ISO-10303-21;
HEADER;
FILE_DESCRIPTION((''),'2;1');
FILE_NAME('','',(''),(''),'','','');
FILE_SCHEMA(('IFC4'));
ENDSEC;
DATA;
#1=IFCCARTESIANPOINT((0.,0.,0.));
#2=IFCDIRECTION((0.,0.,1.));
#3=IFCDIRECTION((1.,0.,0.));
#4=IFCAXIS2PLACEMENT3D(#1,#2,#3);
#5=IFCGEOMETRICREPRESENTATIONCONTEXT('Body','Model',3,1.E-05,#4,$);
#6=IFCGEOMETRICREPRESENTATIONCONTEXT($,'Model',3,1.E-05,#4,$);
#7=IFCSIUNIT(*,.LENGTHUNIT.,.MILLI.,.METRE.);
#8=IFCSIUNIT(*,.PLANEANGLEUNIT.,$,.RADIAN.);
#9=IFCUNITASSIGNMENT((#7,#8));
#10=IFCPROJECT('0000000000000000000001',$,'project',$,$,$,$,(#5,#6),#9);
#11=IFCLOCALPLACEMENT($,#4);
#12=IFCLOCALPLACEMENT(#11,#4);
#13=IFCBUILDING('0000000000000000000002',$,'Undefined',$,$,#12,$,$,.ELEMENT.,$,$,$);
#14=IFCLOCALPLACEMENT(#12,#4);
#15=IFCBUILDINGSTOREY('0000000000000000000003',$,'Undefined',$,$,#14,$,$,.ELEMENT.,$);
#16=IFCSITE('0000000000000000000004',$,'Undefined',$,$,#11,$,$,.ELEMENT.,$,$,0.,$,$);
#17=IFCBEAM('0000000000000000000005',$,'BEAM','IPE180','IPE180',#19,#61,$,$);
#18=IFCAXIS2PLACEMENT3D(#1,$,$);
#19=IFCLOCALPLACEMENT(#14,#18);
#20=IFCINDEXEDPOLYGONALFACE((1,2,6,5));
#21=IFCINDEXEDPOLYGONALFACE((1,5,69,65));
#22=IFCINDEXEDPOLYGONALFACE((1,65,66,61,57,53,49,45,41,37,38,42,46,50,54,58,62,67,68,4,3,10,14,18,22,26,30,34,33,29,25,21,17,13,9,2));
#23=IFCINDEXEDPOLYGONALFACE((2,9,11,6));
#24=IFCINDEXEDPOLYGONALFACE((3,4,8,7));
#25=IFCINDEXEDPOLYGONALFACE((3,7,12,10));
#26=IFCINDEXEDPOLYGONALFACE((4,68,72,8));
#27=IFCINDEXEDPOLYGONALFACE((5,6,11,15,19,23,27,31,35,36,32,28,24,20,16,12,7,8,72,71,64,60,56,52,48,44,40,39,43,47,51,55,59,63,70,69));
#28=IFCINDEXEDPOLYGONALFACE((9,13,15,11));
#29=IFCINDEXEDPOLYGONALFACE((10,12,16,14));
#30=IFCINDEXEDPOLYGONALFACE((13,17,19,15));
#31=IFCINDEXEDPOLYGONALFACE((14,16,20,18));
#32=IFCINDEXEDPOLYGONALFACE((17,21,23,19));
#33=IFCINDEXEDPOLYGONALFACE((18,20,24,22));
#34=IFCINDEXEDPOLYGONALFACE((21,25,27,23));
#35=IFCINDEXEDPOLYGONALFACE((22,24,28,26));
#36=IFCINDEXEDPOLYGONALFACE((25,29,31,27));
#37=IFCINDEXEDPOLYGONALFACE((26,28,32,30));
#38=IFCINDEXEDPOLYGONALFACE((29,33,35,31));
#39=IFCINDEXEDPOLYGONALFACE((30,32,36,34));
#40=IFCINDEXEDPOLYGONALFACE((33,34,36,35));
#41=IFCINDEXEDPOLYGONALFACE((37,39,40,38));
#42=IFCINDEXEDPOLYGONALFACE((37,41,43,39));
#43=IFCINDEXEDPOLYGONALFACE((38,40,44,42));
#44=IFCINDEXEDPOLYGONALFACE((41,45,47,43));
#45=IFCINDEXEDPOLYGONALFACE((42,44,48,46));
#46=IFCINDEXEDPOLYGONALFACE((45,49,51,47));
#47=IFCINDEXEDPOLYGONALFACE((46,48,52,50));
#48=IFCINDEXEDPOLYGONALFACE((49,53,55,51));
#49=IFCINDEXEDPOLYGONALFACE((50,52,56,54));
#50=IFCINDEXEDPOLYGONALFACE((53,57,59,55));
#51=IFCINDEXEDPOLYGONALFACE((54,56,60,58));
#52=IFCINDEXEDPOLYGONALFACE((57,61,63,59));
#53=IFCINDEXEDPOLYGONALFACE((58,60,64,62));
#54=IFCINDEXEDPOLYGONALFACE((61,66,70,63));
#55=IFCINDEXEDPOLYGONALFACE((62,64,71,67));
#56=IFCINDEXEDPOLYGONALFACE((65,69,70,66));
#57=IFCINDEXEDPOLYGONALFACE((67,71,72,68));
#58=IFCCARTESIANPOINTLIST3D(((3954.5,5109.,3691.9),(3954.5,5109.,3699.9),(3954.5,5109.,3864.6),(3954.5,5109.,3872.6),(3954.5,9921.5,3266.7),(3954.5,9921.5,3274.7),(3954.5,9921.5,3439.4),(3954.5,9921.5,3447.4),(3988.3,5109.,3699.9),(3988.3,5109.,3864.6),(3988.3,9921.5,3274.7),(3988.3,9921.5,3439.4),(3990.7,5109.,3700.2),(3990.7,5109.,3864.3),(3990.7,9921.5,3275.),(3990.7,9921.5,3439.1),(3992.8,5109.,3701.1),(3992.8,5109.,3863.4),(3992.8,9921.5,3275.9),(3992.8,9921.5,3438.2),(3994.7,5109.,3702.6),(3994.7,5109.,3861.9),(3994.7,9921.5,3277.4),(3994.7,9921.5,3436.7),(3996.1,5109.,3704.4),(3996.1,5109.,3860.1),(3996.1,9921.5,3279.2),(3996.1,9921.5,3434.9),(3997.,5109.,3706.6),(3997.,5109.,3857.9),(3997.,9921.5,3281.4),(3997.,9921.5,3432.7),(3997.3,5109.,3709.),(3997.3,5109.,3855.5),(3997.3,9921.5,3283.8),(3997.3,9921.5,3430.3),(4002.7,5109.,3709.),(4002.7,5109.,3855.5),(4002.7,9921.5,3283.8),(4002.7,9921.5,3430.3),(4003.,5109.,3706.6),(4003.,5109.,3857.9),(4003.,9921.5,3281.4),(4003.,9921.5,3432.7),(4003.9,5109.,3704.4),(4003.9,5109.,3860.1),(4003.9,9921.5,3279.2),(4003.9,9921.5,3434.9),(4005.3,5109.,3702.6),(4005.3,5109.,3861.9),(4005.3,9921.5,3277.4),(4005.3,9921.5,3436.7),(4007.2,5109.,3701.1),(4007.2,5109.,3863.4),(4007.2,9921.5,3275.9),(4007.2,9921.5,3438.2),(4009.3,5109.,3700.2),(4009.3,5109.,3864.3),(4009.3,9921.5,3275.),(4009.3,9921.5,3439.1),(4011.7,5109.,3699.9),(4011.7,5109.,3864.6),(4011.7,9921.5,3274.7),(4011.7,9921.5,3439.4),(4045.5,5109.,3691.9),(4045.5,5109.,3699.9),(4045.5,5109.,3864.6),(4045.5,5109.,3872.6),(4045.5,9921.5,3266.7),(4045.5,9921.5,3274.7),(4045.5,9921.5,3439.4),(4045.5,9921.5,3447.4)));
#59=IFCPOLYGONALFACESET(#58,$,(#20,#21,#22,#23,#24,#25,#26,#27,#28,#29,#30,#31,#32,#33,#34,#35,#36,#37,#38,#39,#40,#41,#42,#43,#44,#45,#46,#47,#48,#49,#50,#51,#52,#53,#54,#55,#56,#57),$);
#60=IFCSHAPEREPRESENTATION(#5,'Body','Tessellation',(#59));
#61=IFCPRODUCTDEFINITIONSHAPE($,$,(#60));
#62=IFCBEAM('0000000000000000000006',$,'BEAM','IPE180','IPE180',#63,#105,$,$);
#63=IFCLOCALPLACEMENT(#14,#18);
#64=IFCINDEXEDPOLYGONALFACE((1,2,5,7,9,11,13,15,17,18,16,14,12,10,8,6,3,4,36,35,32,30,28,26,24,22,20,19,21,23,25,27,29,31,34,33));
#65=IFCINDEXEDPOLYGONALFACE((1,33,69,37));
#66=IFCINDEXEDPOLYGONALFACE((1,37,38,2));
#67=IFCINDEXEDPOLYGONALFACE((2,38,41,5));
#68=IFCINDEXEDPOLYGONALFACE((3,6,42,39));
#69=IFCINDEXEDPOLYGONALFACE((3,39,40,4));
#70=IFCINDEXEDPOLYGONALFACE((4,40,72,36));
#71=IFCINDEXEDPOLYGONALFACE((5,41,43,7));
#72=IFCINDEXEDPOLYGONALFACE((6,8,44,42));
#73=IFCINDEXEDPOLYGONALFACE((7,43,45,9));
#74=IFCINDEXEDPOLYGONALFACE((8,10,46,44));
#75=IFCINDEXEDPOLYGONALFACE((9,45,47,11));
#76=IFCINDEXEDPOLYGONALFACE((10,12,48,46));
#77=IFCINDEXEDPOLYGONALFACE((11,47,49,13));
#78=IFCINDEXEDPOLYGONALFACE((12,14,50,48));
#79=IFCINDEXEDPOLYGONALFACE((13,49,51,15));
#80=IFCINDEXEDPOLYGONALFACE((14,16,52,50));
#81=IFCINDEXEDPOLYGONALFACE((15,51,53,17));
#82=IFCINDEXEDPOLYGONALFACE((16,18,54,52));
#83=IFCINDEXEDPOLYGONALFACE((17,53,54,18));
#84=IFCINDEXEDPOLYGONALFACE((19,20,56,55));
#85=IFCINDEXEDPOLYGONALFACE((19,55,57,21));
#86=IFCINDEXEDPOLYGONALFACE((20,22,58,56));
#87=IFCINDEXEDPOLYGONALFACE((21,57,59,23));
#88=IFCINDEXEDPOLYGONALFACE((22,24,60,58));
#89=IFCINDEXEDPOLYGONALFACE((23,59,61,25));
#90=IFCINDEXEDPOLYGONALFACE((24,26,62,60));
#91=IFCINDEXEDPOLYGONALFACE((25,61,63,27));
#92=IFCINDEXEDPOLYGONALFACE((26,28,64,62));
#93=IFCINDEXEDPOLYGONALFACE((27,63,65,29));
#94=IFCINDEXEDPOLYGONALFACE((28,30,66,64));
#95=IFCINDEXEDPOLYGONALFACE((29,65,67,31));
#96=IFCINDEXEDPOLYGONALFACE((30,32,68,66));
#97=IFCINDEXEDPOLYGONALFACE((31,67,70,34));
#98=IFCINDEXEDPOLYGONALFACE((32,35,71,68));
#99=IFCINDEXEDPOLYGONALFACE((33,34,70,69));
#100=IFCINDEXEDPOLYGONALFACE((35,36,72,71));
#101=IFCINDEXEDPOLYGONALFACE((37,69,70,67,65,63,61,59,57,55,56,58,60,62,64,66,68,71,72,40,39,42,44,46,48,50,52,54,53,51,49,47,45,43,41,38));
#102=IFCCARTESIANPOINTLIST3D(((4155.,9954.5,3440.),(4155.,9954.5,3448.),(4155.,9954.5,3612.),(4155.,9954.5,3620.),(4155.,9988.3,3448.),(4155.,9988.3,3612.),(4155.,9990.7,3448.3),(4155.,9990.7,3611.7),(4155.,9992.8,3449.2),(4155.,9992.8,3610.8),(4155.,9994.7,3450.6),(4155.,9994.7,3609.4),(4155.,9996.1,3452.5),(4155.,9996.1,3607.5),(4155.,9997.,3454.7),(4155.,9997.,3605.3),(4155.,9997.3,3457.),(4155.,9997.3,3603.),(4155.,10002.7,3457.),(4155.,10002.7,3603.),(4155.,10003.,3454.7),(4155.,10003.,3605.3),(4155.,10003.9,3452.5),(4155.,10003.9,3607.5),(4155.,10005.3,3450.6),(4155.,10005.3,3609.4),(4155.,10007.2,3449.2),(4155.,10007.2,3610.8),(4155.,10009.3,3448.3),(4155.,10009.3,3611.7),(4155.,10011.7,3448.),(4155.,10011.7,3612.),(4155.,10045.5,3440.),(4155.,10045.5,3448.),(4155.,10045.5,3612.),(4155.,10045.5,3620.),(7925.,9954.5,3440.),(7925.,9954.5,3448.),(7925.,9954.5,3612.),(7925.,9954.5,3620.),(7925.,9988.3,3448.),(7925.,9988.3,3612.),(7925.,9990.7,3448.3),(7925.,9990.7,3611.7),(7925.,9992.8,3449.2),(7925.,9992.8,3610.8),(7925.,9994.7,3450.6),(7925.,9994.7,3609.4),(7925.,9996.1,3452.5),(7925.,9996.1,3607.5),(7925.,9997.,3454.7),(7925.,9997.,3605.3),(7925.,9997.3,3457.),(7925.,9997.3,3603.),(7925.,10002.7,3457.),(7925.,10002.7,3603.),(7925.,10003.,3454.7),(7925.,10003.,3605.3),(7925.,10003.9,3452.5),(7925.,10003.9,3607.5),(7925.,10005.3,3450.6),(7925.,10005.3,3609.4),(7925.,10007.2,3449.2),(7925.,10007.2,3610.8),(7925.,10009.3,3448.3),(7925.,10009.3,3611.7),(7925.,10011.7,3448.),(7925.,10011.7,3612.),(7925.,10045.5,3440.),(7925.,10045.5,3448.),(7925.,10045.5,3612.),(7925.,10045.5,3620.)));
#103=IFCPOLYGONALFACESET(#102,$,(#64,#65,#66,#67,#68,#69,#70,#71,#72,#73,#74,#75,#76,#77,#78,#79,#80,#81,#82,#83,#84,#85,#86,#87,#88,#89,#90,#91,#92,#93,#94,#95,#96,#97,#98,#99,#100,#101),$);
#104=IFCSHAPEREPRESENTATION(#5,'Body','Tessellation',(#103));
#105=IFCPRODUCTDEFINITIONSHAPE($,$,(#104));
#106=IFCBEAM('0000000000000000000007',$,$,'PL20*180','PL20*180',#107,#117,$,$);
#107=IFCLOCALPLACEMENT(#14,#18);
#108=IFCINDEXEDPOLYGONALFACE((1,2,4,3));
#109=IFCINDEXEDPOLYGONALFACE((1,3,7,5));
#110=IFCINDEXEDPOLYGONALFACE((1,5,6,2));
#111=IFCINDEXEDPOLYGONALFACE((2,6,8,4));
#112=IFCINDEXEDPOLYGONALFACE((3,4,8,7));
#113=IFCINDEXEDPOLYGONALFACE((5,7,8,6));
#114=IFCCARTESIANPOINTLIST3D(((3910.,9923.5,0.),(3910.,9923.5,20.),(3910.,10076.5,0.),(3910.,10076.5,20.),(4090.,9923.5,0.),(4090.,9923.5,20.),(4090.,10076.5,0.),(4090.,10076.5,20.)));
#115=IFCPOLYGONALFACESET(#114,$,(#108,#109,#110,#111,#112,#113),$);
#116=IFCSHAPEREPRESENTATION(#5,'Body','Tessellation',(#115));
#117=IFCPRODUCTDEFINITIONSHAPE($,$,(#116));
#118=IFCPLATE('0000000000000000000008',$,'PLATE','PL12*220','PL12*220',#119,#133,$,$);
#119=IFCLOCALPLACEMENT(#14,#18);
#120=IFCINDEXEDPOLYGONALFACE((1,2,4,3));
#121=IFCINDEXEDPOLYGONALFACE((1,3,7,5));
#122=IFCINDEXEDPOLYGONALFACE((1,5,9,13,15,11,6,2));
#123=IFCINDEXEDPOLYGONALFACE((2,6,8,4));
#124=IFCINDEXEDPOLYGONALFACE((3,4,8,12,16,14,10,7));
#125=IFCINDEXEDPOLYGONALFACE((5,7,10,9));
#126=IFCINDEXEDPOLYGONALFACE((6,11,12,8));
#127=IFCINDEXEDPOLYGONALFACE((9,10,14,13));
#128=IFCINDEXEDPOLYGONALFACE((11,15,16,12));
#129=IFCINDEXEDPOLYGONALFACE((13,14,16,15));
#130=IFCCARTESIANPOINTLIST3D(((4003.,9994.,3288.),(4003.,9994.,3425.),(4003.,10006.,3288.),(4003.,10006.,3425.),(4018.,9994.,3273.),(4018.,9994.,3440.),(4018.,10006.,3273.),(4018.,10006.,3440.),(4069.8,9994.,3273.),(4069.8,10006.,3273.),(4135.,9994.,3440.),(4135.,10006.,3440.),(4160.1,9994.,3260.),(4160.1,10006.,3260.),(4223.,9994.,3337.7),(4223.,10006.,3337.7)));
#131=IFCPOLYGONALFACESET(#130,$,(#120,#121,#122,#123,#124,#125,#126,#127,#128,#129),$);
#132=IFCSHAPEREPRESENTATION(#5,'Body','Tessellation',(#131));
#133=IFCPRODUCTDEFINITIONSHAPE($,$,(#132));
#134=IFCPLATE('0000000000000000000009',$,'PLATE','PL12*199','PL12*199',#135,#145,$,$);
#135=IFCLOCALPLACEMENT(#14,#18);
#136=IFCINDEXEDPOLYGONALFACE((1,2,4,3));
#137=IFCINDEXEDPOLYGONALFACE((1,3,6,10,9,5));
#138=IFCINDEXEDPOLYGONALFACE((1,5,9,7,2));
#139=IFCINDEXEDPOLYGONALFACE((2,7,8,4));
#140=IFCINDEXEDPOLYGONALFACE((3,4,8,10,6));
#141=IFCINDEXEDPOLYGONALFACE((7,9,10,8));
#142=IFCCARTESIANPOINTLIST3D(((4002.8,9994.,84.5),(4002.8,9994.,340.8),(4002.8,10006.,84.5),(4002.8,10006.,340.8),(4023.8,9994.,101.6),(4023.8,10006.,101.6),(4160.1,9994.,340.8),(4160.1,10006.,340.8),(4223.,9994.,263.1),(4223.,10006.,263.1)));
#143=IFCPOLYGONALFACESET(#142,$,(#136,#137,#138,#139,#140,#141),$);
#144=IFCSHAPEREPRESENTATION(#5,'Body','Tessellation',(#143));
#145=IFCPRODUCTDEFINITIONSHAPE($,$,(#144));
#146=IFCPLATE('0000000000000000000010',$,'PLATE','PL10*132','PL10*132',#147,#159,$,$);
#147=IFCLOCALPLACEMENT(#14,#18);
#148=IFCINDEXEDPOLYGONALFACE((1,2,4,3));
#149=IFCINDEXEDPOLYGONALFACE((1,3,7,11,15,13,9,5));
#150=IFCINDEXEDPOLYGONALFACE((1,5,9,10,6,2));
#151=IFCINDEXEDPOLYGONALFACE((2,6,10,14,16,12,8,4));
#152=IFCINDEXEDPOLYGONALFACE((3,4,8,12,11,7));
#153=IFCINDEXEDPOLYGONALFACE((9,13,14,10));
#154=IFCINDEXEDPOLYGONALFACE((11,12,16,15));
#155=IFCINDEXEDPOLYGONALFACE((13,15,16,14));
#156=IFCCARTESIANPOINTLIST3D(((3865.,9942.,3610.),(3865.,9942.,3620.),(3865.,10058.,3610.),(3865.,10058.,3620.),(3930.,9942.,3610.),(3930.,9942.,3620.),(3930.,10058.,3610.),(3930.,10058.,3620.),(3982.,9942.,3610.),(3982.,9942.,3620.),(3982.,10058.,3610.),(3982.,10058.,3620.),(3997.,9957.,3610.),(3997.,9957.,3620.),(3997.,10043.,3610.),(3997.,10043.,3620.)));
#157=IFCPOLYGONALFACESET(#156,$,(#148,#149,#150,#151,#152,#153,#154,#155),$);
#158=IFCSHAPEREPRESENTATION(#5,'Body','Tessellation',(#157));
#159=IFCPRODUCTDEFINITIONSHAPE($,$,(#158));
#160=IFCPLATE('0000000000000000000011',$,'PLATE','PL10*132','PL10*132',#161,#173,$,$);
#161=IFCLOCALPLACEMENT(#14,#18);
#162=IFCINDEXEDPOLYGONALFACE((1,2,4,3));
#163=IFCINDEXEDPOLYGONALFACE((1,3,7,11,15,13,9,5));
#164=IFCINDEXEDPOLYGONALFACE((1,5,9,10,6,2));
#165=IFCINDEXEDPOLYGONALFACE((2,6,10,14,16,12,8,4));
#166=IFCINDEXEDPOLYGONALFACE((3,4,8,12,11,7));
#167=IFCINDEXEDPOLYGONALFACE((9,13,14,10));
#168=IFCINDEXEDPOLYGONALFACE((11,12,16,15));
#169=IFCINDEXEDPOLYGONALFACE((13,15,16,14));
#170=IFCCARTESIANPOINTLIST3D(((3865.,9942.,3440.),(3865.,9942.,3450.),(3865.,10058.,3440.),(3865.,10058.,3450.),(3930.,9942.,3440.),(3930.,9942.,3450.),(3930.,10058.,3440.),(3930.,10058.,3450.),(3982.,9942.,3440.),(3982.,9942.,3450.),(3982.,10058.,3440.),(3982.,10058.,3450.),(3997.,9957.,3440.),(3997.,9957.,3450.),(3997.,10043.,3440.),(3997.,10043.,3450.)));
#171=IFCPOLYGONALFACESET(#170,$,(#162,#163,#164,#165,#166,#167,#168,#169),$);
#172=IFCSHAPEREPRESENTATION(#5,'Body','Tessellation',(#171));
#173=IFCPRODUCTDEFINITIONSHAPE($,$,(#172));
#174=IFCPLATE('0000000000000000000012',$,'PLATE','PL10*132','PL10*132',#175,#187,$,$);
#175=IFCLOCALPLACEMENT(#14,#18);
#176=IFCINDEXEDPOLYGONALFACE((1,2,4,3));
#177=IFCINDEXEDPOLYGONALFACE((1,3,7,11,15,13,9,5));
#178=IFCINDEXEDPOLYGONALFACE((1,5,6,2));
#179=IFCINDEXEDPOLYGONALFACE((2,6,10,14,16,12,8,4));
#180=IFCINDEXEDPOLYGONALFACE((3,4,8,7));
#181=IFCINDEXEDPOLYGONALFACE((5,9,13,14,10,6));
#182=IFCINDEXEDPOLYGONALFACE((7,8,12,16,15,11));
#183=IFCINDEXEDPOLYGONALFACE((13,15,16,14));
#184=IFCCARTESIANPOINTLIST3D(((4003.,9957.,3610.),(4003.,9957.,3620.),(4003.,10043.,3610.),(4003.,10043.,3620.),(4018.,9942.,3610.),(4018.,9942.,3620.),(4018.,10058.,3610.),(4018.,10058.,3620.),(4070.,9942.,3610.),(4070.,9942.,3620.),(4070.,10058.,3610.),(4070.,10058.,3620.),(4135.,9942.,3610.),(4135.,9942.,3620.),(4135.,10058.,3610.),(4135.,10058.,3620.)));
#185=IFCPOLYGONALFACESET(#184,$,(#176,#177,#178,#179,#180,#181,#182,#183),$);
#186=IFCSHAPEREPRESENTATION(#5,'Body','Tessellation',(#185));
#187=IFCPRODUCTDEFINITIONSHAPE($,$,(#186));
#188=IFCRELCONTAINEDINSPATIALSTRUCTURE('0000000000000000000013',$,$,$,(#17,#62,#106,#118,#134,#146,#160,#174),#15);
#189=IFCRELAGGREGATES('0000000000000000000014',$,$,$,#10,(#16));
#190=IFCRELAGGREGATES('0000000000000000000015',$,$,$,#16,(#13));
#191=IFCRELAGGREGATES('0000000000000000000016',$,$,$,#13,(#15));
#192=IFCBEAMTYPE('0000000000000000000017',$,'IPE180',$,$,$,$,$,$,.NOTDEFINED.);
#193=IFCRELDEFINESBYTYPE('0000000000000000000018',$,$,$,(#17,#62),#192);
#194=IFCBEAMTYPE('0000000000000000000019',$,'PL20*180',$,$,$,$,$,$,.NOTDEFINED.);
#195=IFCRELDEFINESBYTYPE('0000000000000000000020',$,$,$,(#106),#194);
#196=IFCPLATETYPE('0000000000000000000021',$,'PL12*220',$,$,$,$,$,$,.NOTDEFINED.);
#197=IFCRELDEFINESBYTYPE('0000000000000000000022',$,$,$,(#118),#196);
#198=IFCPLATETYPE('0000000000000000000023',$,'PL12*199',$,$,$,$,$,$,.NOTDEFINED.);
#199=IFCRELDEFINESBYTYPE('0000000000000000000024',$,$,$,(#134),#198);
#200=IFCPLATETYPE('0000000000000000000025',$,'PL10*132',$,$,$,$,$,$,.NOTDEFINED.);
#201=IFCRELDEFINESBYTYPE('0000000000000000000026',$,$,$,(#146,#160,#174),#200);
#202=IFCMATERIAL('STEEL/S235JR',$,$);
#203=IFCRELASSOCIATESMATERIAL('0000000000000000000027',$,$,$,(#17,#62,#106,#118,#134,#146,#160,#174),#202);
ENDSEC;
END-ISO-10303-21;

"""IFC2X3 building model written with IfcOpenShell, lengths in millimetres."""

from ifc_helpers import new_model, si_unit, frame, origin_with_axes, origin_2d_with_axis, place, context, project, spatial, polyline, rectangle, i_section, outline, extrude, clip, halfspace, material, type_object, element, save


model = new_model("IFC2X3")

# Units and contexts
model_context_1 = context("Model", 3, precision=1e-05, world=origin_with_axes(), identifier="Body")
model_context_2 = context("Model", 3, precision=1e-05, world=origin_with_axes())
ifc_project = project(units=[si_unit("LENGTHUNIT", "METRE", prefix="MILLI"), si_unit("PLANEANGLEUNIT", "RADIAN")], contexts=[model_context_1, model_context_2])

# Site, building, storey
site_placement = place(None, origin_with_axes())
site = spatial("IfcSite", under=ifc_project, at=site_placement, Name="Undefined", CompositionType="ELEMENT", RefElevation=0.0)
building_placement = place(site_placement, origin_with_axes())
building = spatial("IfcBuilding", under=site, at=building_placement, Name="Undefined", CompositionType="ELEMENT")
storey_placement = place(building_placement, origin_with_axes())
storey = spatial("IfcBuildingStorey", under=building, at=storey_placement, Name="Undefined", CompositionType="ELEMENT")

# Shared definitions
ifc_material = material(Name="STEEL/S235JR")

# Beams
beam_type_1 = type_object("IfcBeamType", Name="IPE180", PredefinedType="NOTDEFINED")
beam_1_placement = place(storey_placement, frame((4000.0, 9941.1, 3355.3), z_axis=(0.0, 0.08801, 0.99612), x_axis=(0.0, -0.99612, 0.08801)))
element("IfcBeam", 1, at=beam_1_placement, inside=storey, type_object=beam_type_1, material=ifc_material, Name="BEAM", Description="IPE180", ObjectType="IPE180", context=model_context_1, shape_type="Clipping", body=[
    clip(clip(extrude(i_section(OverallWidth=91.0, OverallDepth=180.0, WebThickness=5.3, FlangeThickness=8.0, FilletRadius=9.0, at=origin_2d_with_axis()), frame((4867.0, 0.0, 0.0), z_axis=(-1.0, 0.0, 0.0), x_axis=(0.0, -1.0, 0.0)), (0.0, 0.0, 1.0), 4863.4), halfspace(frame((11.7, 0.0, -90.0), z_axis=(0.99612, 0.0, -0.08801), x_axis=(0.0, -1.0, 0.0)), True)), halfspace(frame((4843.1, 0.0, -88.9), z_axis=(-0.99612, 0.0, 0.08801), x_axis=(0.0, 1.0, 0.0)), True)),
])
beam_2_placement = place(storey_placement, frame((4155.0, 10000.0, 3530.0), z_axis=(0.0, 0.0, 1.0), x_axis=(1.0, 0.0, 0.0)))
element("IfcBeam", 2, at=beam_2_placement, inside=storey, type_object=beam_type_1, material=ifc_material, Name="BEAM", Description="IPE180", ObjectType="IPE180", context=model_context_1, shape_type="SweptSolid", body=[
    extrude(i_section(OverallWidth=91.0, OverallDepth=180.0, WebThickness=5.3, FlangeThickness=8.0, FilletRadius=9.0, at=origin_2d_with_axis()), frame((3770.0, 0.0, 0.0), z_axis=(-1.0, 0.0, 0.0), x_axis=(0.0, -1.0, 0.0)), (0.0, 0.0, 1.0), 3770.0),
])
beam_type_2 = type_object("IfcBeamType", Name="PL20*180", PredefinedType="NOTDEFINED")
beam_3_placement = place(storey_placement, frame((4000.0, 9923.5, 10.0), z_axis=(-1.0, 0.0, 0.0), x_axis=(0.0, 1.0, 0.0)))
element("IfcBeam", 3, at=beam_3_placement, inside=storey, type_object=beam_type_2, material=ifc_material, Description="PL20*180", ObjectType="PL20*180", context=model_context_1, shape_type="SweptSolid", body=[
    extrude(rectangle(XDim=20.0, YDim=180.0, at=origin_2d_with_axis()), frame((153.0, 0.0, 0.0), z_axis=(-1.0, 0.0, 0.0), x_axis=(0.0, -1.0, 0.0)), (0.0, 0.0, 1.0), 153.0),
])

# Plates
plate_type_1 = type_object("IfcPlateType", Name="PL12*220", PredefinedType="NOTDEFINED")
plate_1_placement = place(storey_placement, frame((4003.0, 10000.0, 3440.0), z_axis=(0.0, 1.0, 0.0), x_axis=(1.0, 0.0, 0.0)))
element("IfcPlate", 4, at=plate_1_placement, inside=storey, type_object=plate_type_1, material=ifc_material, Name="PLATE", Description="PL12*220", ObjectType="PL12*220", context=model_context_1, shape_type="SweptSolid", body=[
    extrude(outline(polyline([(0.0, 15.0), (15.0, 0.0), (132.0, 0.0), (220.0, 102.3), (157.1, 180.0), (66.8, 167.0), (15.0, 167.0), (0.0, 152.0), (0.0, 15.0)])), frame((0.0, 0.0, -6.0), z_axis=(0.0, 0.0, 1.0), x_axis=(1.0, 0.0, 0.0)), (0.0, 0.0, 1.0), 12.0),
])
plate_type_2 = type_object("IfcPlateType", Name="PL12*199", PredefinedType="NOTDEFINED")
plate_2_placement = place(storey_placement, frame((4002.8, 10000.0, 84.5), z_axis=(0.0, 1.0, 0.0), x_axis=(0.0, 0.0, 1.0)))
element("IfcPlate", 5, at=plate_2_placement, inside=storey, type_object=plate_type_2, material=ifc_material, Name="PLATE", Description="PL12*199", ObjectType="PL12*199", context=model_context_1, shape_type="SweptSolid", body=[
    extrude(outline(polyline([(0.0, 0.0), (256.3, 0.0), (256.3, 157.3), (178.6, 220.3), (17.1, 21.1), (0.0, 0.0)])), frame((0.0, 0.0, -6.0), z_axis=(0.0, 0.0, 1.0), x_axis=(1.0, 0.0, 0.0)), (0.0, 0.0, 1.0), 12.0),
])
plate_type_3 = type_object("IfcPlateType", Name="PL10*132", PredefinedType="NOTDEFINED")
for number, where, z_axis, x_axis, name in (
    (6, (3997.0, 10058.0, 3615.0), (0.0, 0.0, 1.0), (-1.0, 0.0, 0.0), "PLATE"),
    (7, (3997.0, 10058.0, 3445.0), (0.0, 0.0, 1.0), (-1.0, 0.0, 0.0), "PLATE"),
    (8, (4003.0, 10058.0, 3615.0), (0.0, 0.0, -1.0), (1.0, 0.0, 0.0), "PLATE"),
):
    element("IfcPlate", number, at=place(storey_placement, frame(where, z_axis=z_axis, x_axis=x_axis)), inside=storey, type_object=plate_type_3, material=ifc_material, Name=name, Description="PL10*132", ObjectType="PL10*132", context=model_context_1, shape_type="SweptSolid", body=[
        extrude(outline(polyline([(0.0, 15.0), (15.0, 0.0), (67.0, 0.0), (132.0, 0.0), (132.0, 116.0), (67.0, 116.0), (15.0, 116.0), (0.0, 101.0), (0.0, 15.0)])), frame((0.0, 0.0, -5.0), z_axis=(0.0, 0.0, 1.0), x_axis=(1.0, 0.0, 0.0)), (0.0, 0.0, 1.0), 10.0),
    ])

save(model, "model.ifc")
